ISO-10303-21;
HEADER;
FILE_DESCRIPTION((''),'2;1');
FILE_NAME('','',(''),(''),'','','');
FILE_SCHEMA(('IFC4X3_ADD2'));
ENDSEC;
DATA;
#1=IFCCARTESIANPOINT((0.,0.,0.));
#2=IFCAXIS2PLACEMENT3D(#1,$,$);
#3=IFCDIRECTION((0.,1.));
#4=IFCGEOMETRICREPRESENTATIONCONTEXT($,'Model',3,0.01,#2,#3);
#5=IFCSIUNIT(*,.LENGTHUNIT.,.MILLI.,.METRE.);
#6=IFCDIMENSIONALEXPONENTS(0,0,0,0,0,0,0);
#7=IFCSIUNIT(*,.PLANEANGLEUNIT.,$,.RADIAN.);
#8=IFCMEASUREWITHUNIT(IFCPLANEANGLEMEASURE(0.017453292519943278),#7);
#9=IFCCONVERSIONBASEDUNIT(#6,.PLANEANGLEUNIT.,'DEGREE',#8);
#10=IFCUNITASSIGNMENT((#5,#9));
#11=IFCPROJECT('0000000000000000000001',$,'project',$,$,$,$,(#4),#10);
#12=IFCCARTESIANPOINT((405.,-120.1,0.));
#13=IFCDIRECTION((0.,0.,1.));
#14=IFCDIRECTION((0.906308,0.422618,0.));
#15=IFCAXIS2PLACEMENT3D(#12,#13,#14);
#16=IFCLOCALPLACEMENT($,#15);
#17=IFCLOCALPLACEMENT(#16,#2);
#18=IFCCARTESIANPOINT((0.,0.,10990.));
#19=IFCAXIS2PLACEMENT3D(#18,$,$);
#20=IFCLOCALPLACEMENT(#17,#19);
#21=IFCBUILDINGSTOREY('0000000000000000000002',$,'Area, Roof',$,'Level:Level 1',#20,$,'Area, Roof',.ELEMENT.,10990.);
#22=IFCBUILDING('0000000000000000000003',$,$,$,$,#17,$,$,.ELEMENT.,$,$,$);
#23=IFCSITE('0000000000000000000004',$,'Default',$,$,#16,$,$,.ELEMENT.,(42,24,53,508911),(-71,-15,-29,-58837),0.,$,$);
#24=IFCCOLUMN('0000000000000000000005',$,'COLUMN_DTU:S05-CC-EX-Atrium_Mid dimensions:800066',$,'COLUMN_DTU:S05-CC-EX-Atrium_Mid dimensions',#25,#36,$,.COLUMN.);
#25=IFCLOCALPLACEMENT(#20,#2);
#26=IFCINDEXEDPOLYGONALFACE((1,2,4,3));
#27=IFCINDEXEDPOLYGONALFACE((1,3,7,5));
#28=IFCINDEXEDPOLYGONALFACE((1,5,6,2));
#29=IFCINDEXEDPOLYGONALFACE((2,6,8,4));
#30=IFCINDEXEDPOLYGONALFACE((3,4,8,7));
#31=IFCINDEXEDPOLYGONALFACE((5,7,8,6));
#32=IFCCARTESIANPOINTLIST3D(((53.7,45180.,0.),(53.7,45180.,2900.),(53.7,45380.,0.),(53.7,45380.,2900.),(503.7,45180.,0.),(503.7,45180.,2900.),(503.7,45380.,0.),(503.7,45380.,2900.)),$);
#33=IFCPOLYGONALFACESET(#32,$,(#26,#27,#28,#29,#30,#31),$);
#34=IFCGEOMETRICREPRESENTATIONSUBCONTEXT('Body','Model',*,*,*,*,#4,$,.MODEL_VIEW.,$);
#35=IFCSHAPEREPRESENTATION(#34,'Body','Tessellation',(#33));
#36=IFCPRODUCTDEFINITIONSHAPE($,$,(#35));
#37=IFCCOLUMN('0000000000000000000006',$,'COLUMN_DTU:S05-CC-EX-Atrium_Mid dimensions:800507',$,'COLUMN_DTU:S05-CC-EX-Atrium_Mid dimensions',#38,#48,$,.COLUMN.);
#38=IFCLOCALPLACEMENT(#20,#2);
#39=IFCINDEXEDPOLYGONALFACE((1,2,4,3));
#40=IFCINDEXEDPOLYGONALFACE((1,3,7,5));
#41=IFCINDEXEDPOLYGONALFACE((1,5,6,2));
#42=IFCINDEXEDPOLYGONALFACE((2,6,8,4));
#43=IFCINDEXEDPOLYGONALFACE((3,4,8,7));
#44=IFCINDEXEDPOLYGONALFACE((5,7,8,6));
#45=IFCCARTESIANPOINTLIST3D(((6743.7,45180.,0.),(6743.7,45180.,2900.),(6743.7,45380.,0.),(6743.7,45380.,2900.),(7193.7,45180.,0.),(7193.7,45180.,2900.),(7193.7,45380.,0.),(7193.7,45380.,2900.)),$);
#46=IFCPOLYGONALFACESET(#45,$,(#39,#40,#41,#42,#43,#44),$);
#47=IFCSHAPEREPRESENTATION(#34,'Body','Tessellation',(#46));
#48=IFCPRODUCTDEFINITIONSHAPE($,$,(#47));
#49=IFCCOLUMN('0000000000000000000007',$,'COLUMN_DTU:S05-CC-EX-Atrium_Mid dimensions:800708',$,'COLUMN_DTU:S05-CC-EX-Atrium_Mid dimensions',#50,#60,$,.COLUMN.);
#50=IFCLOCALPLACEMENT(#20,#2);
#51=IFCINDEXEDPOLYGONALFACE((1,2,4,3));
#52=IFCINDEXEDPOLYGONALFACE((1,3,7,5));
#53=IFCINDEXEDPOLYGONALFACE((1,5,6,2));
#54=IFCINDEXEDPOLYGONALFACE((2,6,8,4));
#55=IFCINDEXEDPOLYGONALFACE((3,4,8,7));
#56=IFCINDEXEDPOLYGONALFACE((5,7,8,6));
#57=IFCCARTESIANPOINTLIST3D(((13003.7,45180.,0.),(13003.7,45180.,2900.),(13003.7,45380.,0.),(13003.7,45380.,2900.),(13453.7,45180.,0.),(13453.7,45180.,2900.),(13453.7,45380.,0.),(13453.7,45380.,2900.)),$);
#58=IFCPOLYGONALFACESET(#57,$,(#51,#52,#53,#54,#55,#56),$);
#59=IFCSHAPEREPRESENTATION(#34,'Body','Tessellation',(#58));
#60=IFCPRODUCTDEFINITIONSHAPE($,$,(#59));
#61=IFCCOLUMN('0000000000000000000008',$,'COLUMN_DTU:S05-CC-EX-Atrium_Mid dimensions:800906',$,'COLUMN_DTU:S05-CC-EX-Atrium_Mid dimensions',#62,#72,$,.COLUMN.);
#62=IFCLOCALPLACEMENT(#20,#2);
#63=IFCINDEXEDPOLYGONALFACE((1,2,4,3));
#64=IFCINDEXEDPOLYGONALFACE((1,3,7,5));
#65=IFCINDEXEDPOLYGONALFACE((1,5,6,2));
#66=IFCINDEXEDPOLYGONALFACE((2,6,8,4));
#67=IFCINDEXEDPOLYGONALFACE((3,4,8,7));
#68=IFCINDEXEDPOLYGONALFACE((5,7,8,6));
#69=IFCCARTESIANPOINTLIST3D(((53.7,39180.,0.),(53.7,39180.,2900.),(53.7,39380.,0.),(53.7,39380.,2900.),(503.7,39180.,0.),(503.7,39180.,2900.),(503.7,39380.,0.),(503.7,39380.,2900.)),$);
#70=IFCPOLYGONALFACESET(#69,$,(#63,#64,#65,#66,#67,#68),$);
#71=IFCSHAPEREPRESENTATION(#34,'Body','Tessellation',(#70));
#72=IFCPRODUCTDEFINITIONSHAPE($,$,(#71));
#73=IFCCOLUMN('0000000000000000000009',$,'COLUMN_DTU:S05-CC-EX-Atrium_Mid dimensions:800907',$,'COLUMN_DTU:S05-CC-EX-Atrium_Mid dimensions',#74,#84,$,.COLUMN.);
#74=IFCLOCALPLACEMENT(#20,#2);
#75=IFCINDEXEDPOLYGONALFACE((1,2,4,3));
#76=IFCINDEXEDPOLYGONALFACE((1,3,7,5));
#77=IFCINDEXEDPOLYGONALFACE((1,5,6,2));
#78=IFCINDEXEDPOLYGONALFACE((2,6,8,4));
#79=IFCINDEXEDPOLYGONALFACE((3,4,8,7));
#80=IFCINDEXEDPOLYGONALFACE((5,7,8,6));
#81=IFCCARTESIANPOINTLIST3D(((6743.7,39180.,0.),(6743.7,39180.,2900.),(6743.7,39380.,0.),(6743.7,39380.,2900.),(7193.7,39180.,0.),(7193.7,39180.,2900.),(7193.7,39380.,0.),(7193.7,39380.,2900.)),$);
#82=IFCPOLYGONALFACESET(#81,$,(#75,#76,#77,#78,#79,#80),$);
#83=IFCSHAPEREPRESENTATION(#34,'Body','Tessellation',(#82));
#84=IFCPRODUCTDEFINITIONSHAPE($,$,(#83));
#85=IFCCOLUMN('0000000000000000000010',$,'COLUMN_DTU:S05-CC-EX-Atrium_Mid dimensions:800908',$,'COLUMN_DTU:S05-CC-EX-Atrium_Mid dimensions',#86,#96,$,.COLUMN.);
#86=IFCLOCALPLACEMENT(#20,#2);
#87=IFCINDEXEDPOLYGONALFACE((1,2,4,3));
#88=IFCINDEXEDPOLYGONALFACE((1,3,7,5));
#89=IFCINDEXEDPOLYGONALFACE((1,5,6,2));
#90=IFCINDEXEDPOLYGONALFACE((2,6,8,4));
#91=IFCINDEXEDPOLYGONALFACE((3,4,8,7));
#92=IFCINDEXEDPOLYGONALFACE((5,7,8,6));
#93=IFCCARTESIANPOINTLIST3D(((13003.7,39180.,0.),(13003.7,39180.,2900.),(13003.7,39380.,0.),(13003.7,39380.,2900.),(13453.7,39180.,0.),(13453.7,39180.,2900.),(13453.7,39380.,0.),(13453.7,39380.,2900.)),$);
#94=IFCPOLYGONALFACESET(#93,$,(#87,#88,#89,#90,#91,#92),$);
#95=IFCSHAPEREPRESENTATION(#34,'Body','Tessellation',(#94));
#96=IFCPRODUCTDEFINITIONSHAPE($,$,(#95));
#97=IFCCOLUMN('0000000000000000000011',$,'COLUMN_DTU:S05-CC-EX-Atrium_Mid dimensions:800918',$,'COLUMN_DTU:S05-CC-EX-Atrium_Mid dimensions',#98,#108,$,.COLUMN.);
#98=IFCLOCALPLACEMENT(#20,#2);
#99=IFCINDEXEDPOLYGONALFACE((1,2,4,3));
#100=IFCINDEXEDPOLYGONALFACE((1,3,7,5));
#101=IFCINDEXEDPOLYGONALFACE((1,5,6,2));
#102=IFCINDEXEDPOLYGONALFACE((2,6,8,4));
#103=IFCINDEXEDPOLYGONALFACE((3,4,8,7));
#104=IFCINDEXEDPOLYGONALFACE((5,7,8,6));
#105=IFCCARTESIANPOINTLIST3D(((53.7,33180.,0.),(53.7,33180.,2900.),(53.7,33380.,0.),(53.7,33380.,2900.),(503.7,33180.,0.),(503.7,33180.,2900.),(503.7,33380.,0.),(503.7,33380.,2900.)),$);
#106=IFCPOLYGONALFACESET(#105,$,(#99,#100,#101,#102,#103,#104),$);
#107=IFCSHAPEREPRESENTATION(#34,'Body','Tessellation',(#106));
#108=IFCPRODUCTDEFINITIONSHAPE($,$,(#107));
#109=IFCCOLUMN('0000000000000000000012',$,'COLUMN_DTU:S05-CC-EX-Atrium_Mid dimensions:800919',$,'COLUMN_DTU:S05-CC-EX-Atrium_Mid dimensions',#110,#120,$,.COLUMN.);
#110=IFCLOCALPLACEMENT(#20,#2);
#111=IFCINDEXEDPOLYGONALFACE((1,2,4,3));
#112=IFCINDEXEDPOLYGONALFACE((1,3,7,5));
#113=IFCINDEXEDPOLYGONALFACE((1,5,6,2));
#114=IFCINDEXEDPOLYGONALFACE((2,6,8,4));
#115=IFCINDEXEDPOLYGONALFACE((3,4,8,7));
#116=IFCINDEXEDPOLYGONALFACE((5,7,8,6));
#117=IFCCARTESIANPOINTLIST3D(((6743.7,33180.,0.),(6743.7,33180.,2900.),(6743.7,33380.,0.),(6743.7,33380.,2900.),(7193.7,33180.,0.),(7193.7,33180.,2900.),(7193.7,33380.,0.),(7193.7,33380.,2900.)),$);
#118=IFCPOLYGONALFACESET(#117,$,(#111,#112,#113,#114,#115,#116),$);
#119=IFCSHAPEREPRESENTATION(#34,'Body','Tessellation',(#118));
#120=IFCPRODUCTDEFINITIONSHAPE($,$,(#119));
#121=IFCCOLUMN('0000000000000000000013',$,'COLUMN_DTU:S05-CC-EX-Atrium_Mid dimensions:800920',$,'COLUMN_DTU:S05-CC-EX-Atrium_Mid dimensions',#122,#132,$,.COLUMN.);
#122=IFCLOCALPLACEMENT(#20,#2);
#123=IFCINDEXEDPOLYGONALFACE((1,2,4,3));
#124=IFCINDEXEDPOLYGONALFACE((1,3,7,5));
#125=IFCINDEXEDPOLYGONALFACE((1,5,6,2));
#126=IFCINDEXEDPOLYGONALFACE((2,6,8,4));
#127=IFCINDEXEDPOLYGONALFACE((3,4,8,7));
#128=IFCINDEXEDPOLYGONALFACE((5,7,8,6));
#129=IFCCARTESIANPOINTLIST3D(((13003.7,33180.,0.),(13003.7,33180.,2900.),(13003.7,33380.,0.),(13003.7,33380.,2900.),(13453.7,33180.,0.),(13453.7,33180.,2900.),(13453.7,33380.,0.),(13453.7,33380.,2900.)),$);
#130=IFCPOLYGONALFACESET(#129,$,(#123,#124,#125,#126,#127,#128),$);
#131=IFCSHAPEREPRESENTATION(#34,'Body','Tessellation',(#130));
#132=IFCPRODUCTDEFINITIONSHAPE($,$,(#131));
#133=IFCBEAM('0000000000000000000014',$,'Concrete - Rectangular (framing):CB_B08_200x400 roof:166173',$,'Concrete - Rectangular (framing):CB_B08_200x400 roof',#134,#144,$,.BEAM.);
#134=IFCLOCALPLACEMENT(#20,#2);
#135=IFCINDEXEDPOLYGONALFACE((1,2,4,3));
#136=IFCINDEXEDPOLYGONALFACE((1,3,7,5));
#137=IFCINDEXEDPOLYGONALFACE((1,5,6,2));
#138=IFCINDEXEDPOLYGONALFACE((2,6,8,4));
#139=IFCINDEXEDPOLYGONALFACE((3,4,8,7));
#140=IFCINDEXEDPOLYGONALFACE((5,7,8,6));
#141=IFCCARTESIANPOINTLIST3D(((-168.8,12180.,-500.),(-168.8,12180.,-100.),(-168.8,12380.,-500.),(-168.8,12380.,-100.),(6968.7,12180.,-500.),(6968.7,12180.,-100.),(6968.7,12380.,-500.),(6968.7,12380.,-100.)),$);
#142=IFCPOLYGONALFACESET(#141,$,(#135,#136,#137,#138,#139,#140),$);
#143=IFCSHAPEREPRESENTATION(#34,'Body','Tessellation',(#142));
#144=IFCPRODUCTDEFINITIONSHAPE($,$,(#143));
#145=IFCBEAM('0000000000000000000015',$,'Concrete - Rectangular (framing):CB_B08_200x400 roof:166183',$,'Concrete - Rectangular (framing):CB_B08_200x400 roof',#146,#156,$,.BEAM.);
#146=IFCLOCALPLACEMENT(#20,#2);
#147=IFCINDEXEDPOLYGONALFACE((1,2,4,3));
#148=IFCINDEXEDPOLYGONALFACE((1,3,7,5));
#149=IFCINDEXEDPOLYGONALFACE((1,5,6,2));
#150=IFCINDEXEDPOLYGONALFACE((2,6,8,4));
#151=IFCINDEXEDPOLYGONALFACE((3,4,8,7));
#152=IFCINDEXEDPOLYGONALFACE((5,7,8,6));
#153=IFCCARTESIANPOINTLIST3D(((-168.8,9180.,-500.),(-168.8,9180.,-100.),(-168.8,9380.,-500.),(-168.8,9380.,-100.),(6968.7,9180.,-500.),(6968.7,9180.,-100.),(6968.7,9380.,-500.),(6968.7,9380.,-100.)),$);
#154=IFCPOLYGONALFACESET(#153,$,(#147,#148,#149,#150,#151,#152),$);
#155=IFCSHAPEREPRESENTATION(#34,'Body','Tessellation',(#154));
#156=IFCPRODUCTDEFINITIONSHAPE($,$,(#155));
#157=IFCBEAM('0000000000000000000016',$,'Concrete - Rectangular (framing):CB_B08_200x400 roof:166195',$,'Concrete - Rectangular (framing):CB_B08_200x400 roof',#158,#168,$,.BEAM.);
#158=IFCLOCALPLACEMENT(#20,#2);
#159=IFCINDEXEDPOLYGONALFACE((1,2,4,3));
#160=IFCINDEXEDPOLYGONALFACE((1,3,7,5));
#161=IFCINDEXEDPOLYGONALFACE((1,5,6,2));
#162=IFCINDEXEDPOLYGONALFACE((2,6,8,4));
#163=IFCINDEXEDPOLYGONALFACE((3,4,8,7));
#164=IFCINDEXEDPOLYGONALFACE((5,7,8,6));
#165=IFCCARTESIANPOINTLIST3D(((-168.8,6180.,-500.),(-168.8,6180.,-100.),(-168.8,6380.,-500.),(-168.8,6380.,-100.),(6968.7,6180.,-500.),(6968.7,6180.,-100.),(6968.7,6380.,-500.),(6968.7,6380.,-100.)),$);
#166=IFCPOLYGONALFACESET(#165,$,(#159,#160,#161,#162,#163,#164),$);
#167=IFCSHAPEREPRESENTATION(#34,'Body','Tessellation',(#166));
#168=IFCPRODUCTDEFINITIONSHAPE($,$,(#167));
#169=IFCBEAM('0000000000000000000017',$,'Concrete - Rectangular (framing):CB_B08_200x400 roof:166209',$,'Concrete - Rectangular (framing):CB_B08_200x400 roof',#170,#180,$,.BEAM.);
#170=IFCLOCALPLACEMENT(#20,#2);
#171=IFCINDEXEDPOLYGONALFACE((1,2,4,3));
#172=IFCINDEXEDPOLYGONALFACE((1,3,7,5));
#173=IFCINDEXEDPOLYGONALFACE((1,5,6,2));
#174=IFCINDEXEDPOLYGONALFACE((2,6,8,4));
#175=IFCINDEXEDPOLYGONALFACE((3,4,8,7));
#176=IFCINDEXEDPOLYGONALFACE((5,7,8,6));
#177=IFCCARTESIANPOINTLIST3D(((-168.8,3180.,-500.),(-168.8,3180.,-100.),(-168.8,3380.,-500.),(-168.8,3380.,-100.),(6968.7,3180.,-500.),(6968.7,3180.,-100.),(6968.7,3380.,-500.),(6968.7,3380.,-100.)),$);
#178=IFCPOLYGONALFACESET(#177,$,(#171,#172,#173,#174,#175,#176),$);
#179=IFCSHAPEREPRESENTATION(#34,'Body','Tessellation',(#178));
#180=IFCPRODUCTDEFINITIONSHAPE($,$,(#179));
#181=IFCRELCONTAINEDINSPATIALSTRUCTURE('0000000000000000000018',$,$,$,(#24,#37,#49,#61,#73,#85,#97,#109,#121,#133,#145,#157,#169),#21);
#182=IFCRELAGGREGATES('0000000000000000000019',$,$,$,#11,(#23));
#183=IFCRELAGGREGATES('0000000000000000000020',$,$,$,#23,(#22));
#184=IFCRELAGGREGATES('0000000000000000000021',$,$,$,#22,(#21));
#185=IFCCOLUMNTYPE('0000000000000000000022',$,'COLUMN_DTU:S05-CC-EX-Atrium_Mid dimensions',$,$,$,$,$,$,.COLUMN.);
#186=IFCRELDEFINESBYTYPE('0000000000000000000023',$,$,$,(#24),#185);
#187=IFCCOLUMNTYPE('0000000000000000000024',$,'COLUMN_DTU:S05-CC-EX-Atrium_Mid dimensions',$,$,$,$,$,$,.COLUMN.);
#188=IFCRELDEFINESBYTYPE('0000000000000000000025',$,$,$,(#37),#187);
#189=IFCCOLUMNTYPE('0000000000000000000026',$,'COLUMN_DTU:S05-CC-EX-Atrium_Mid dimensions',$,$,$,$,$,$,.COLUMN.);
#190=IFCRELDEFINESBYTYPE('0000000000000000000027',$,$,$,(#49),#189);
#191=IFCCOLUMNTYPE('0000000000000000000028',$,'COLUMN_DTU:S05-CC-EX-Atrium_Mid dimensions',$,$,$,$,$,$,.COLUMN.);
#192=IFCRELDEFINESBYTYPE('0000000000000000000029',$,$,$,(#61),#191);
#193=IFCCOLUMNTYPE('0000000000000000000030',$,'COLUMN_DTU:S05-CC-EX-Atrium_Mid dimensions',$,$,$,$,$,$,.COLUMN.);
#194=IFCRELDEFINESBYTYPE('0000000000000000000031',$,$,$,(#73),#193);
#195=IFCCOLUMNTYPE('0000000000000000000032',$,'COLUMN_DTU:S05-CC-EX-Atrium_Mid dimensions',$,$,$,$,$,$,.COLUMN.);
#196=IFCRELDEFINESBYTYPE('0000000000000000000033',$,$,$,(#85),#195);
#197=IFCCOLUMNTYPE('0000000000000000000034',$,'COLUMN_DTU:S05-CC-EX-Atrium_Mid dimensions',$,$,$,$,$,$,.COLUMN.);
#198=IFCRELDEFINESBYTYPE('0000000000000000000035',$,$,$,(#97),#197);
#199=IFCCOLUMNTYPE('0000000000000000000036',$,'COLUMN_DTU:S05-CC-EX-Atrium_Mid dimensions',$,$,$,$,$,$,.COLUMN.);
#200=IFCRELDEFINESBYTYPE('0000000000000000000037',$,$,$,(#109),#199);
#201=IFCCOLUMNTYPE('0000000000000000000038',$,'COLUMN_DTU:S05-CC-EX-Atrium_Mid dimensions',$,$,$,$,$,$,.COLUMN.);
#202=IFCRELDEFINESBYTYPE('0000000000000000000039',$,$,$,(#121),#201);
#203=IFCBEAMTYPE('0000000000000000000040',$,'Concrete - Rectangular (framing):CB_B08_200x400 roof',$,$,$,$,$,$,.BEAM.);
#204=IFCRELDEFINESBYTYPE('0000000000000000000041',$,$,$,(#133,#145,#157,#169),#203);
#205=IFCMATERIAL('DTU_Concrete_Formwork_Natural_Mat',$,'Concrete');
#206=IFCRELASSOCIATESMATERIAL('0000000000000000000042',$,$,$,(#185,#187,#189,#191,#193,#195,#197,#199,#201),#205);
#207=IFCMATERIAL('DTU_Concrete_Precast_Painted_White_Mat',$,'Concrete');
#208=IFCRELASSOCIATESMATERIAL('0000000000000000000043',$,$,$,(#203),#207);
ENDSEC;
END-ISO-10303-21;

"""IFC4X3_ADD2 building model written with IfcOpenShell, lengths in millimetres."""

from ifc_helpers import new_model, entity, si_unit, converted_unit, direction, frame, frame_2d, origin, origin_2d_with_axis, place, context, subcontext, project, spatial, rectangle, extrude, source, transform, mapped, material, material_profile, profile_set, type_object, type_shapes, element, save


model = new_model("IFC4X3_ADD2")

# Units and contexts
model_context = context("Model", 3, precision=0.01, world=origin(), true_north=direction((0.0, 1.0)))
body_context = subcontext(model_context, "Body", "Model", "MODEL_VIEW")
ifc_project = project(units=[si_unit("LENGTHUNIT", "METRE", prefix="MILLI"), converted_unit("PLANEANGLEUNIT", "DEGREE", entity("IfcPlaneAngleMeasure", 0.017453292519943278), si_unit("PLANEANGLEUNIT", "RADIAN"), dimensions=[0, 0, 0, 0, 0, 0, 0])], contexts=[model_context])

# Site, building, storey
site_placement = place(None, frame((405.0, -120.1, 0.0), z_axis=(0.0, 0.0, 1.0), x_axis=(0.906308, 0.422618, 0.0)))
site = spatial("IfcSite", under=ifc_project, at=site_placement, Name="Default", CompositionType="ELEMENT", RefLatitude=(42, 24, 53, 508911), RefLongitude=(-71, -15, -29, -58837), RefElevation=0.0)
building_placement = place(site_placement, origin())
building = spatial("IfcBuilding", under=site, at=building_placement, CompositionType="ELEMENT")
storey_placement = place(building_placement, frame((0.0, 0.0, 10990.0)))
storey = spatial("IfcBuildingStorey", under=building, at=storey_placement, Name="Area, Roof", ObjectType="Level:Level 1", LongName="Area, Roof", CompositionType="ELEMENT", Elevation=10990.0)

# Columns
ifc_material_1 = material(Name="DTU_Concrete_Formwork_Natural_Mat", Category="Concrete")
ifc_material_profile_1 = material_profile(ifc_material_1, rectangle(XDim=200.0, YDim=450.0, at=frame_2d((0.0, 0.0), x_axis=(1.0, 0.0))), Name="S05-CC-EX-Atrium_Mid dimensions")
ifc_profile_set_1 = profile_set([ifc_material_profile_1], Name="S05-CC-EX-Atrium_Mid dimensions")
column_type_1 = type_object("IfcColumnType", Name="COLUMN_DTU:S05-CC-EX-Atrium_Mid dimensions", PredefinedType="COLUMN", material=ifc_profile_set_1)
shared_shape_1 = source(origin(), body_context, "Body", "SweptSolid", [
    extrude(rectangle(XDim=200.0, YDim=450.0, at=frame_2d((0.0, 0.0), x_axis=(1.0, 0.0))), frame((278.7, 45280.0, 10990.0), z_axis=(0.0, 0.0, 1.0), x_axis=(0.0, -1.0, 0.0)), (0.0, 0.0, 1.0), 2900.0),
])
type_shapes(column_type_1, [shared_shape_1])
column_1_placement = place(storey_placement, frame((0.0, 0.0, -10990.0)))
element("IfcColumn", 1, at=column_1_placement, inside=storey, type_object=column_type_1, Name="COLUMN_DTU:S05-CC-EX-Atrium_Mid dimensions:800066", ObjectType="COLUMN_DTU:S05-CC-EX-Atrium_Mid dimensions", PredefinedType="COLUMN", context=body_context, shape_type="MappedRepresentation", body=[
    mapped(shared_shape_1, transform((0.0, 0.0, 0.0), scale=1.0)),
])
column_type_2 = type_object("IfcColumnType", Name="COLUMN_DTU:S05-CC-EX-Atrium_Mid dimensions", PredefinedType="COLUMN", material=ifc_profile_set_1)
shared_shape_2 = source(origin(), body_context, "Body", "SweptSolid", [
    extrude(rectangle(XDim=200.0, YDim=450.0, at=frame_2d((0.0, 0.0), x_axis=(1.0, 0.0))), frame((6968.7, 45280.0, 10990.0), z_axis=(0.0, 0.0, 1.0), x_axis=(0.0, -1.0, 0.0)), (0.0, 0.0, 1.0), 2900.0),
])
type_shapes(column_type_2, [shared_shape_2])
column_2_placement = place(storey_placement, frame((0.0, 0.0, -10990.0)))
element("IfcColumn", 2, at=column_2_placement, inside=storey, type_object=column_type_2, Name="COLUMN_DTU:S05-CC-EX-Atrium_Mid dimensions:800507", ObjectType="COLUMN_DTU:S05-CC-EX-Atrium_Mid dimensions", PredefinedType="COLUMN", context=body_context, shape_type="MappedRepresentation", body=[
    mapped(shared_shape_2, transform((0.0, 0.0, 0.0), scale=1.0)),
])
column_type_3 = type_object("IfcColumnType", Name="COLUMN_DTU:S05-CC-EX-Atrium_Mid dimensions", PredefinedType="COLUMN", material=ifc_profile_set_1)
shared_shape_3 = source(origin(), body_context, "Body", "SweptSolid", [
    extrude(rectangle(XDim=200.0, YDim=450.0, at=frame_2d((0.0, 0.0), x_axis=(1.0, 0.0))), frame((13228.7, 45280.0, 10990.0), z_axis=(0.0, 0.0, 1.0), x_axis=(0.0, -1.0, 0.0)), (0.0, 0.0, 1.0), 2900.0),
])
type_shapes(column_type_3, [shared_shape_3])
column_3_placement = place(storey_placement, frame((0.0, 0.0, -10990.0)))
element("IfcColumn", 3, at=column_3_placement, inside=storey, type_object=column_type_3, Name="COLUMN_DTU:S05-CC-EX-Atrium_Mid dimensions:800708", ObjectType="COLUMN_DTU:S05-CC-EX-Atrium_Mid dimensions", PredefinedType="COLUMN", context=body_context, shape_type="MappedRepresentation", body=[
    mapped(shared_shape_3, transform((0.0, 0.0, 0.0), scale=1.0)),
])
column_type_4 = type_object("IfcColumnType", Name="COLUMN_DTU:S05-CC-EX-Atrium_Mid dimensions", PredefinedType="COLUMN", material=ifc_profile_set_1)
shared_shape_4 = source(origin(), body_context, "Body", "SweptSolid", [
    extrude(rectangle(XDim=200.0, YDim=450.0, at=frame_2d((0.0, 0.0), x_axis=(1.0, 0.0))), frame((278.7, 39280.0, 10990.0), z_axis=(0.0, 0.0, 1.0), x_axis=(0.0, -1.0, 0.0)), (0.0, 0.0, 1.0), 2900.0),
])
type_shapes(column_type_4, [shared_shape_4])
column_4_placement = place(storey_placement, frame((0.0, 0.0, -10990.0)))
element("IfcColumn", 4, at=column_4_placement, inside=storey, type_object=column_type_4, Name="COLUMN_DTU:S05-CC-EX-Atrium_Mid dimensions:800906", ObjectType="COLUMN_DTU:S05-CC-EX-Atrium_Mid dimensions", PredefinedType="COLUMN", context=body_context, shape_type="MappedRepresentation", body=[
    mapped(shared_shape_4, transform((0.0, 0.0, 0.0), scale=1.0)),
])
column_type_5 = type_object("IfcColumnType", Name="COLUMN_DTU:S05-CC-EX-Atrium_Mid dimensions", PredefinedType="COLUMN", material=ifc_profile_set_1)
shared_shape_5 = source(origin(), body_context, "Body", "SweptSolid", [
    extrude(rectangle(XDim=200.0, YDim=450.0, at=frame_2d((0.0, 0.0), x_axis=(1.0, 0.0))), frame((6968.7, 39280.0, 10990.0), z_axis=(0.0, 0.0, 1.0), x_axis=(0.0, -1.0, 0.0)), (0.0, 0.0, 1.0), 2900.0),
])
type_shapes(column_type_5, [shared_shape_5])
column_5_placement = place(storey_placement, frame((0.0, 0.0, -10990.0)))
element("IfcColumn", 5, at=column_5_placement, inside=storey, type_object=column_type_5, Name="COLUMN_DTU:S05-CC-EX-Atrium_Mid dimensions:800907", ObjectType="COLUMN_DTU:S05-CC-EX-Atrium_Mid dimensions", PredefinedType="COLUMN", context=body_context, shape_type="MappedRepresentation", body=[
    mapped(shared_shape_5, transform((0.0, 0.0, 0.0), scale=1.0)),
])
column_type_6 = type_object("IfcColumnType", Name="COLUMN_DTU:S05-CC-EX-Atrium_Mid dimensions", PredefinedType="COLUMN", material=ifc_profile_set_1)
shared_shape_6 = source(origin(), body_context, "Body", "SweptSolid", [
    extrude(rectangle(XDim=200.0, YDim=450.0, at=frame_2d((0.0, 0.0), x_axis=(1.0, 0.0))), frame((13228.7, 39280.0, 10990.0), z_axis=(0.0, 0.0, 1.0), x_axis=(0.0, -1.0, 0.0)), (0.0, 0.0, 1.0), 2900.0),
])
type_shapes(column_type_6, [shared_shape_6])
column_6_placement = place(storey_placement, frame((0.0, 0.0, -10990.0)))
element("IfcColumn", 6, at=column_6_placement, inside=storey, type_object=column_type_6, Name="COLUMN_DTU:S05-CC-EX-Atrium_Mid dimensions:800908", ObjectType="COLUMN_DTU:S05-CC-EX-Atrium_Mid dimensions", PredefinedType="COLUMN", context=body_context, shape_type="MappedRepresentation", body=[
    mapped(shared_shape_6, transform((0.0, 0.0, 0.0), scale=1.0)),
])
column_type_7 = type_object("IfcColumnType", Name="COLUMN_DTU:S05-CC-EX-Atrium_Mid dimensions", PredefinedType="COLUMN", material=ifc_profile_set_1)
shared_shape_7 = source(origin(), body_context, "Body", "SweptSolid", [
    extrude(rectangle(XDim=200.0, YDim=450.0, at=frame_2d((0.0, 0.0), x_axis=(1.0, 0.0))), frame((278.7, 33280.0, 10990.0), z_axis=(0.0, 0.0, 1.0), x_axis=(0.0, -1.0, 0.0)), (0.0, 0.0, 1.0), 2900.0),
])
type_shapes(column_type_7, [shared_shape_7])
column_7_placement = place(storey_placement, frame((0.0, 0.0, -10990.0)))
element("IfcColumn", 7, at=column_7_placement, inside=storey, type_object=column_type_7, Name="COLUMN_DTU:S05-CC-EX-Atrium_Mid dimensions:800918", ObjectType="COLUMN_DTU:S05-CC-EX-Atrium_Mid dimensions", PredefinedType="COLUMN", context=body_context, shape_type="MappedRepresentation", body=[
    mapped(shared_shape_7, transform((0.0, 0.0, 0.0), scale=1.0)),
])
column_type_8 = type_object("IfcColumnType", Name="COLUMN_DTU:S05-CC-EX-Atrium_Mid dimensions", PredefinedType="COLUMN", material=ifc_profile_set_1)
shared_shape_8 = source(origin(), body_context, "Body", "SweptSolid", [
    extrude(rectangle(XDim=200.0, YDim=450.0, at=frame_2d((0.0, 0.0), x_axis=(1.0, 0.0))), frame((6968.7, 33280.0, 10990.0), z_axis=(0.0, 0.0, 1.0), x_axis=(0.0, -1.0, 0.0)), (0.0, 0.0, 1.0), 2900.0),
])
type_shapes(column_type_8, [shared_shape_8])
column_8_placement = place(storey_placement, frame((0.0, 0.0, -10990.0)))
element("IfcColumn", 8, at=column_8_placement, inside=storey, type_object=column_type_8, Name="COLUMN_DTU:S05-CC-EX-Atrium_Mid dimensions:800919", ObjectType="COLUMN_DTU:S05-CC-EX-Atrium_Mid dimensions", PredefinedType="COLUMN", context=body_context, shape_type="MappedRepresentation", body=[
    mapped(shared_shape_8, transform((0.0, 0.0, 0.0), scale=1.0)),
])
column_type_9 = type_object("IfcColumnType", Name="COLUMN_DTU:S05-CC-EX-Atrium_Mid dimensions", PredefinedType="COLUMN", material=ifc_profile_set_1)
shared_shape_9 = source(origin(), body_context, "Body", "SweptSolid", [
    extrude(rectangle(XDim=200.0, YDim=450.0, at=frame_2d((0.0, 0.0), x_axis=(1.0, 0.0))), frame((13228.7, 33280.0, 10990.0), z_axis=(0.0, 0.0, 1.0), x_axis=(0.0, -1.0, 0.0)), (0.0, 0.0, 1.0), 2900.0),
])
type_shapes(column_type_9, [shared_shape_9])
column_9_placement = place(storey_placement, frame((0.0, 0.0, -10990.0)))
element("IfcColumn", 9, at=column_9_placement, inside=storey, type_object=column_type_9, Name="COLUMN_DTU:S05-CC-EX-Atrium_Mid dimensions:800920", ObjectType="COLUMN_DTU:S05-CC-EX-Atrium_Mid dimensions", PredefinedType="COLUMN", context=body_context, shape_type="MappedRepresentation", body=[
    mapped(shared_shape_9, transform((0.0, 0.0, 0.0), scale=1.0)),
])

# Beams
ifc_material_2 = material(Name="DTU_Concrete_Precast_Painted_White_Mat", Category="Concrete")
ifc_material_profile_2 = material_profile(ifc_material_2, rectangle(XDim=7137.5, YDim=200.0, at=origin_2d_with_axis()), Name="CB_B08_200x400 roof")
ifc_profile_set_2 = profile_set([ifc_material_profile_2], Name="CB_B08_200x400 roof")
beam_type_1 = type_object("IfcBeamType", Name="Concrete - Rectangular (framing):CB_B08_200x400 roof", PredefinedType="BEAM", material=ifc_profile_set_2)
shared_shape_10 = source(origin(), body_context, "Body", "SweptSolid", [
    extrude(rectangle(XDim=7137.5, YDim=200.0, at=origin_2d_with_axis()), frame((6.3, 0.0, -200.0), z_axis=(0.0, 0.0, 1.0), x_axis=(-1.0, 0.0, 0.0)), (0.0, 0.0, 1.0), 400.0),
])
type_shapes(beam_type_1, [shared_shape_10])
for number, where, z_axis, x_axis, name in (
    (10, (3406.2, 12280.0, -300.0), (0.0, 0.0, 1.0), (-1.0, 0.0, 0.0), "Concrete - Rectangular (framing):CB_B08_200x400 roof:166173"),
    (11, (3406.2, 9280.0, -300.0), (0.0, 0.0, 1.0), (-1.0, 0.0, 0.0), "Concrete - Rectangular (framing):CB_B08_200x400 roof:166183"),
    (12, (3406.2, 6280.0, -300.0), (0.0, 0.0, 1.0), (-1.0, 0.0, 0.0), "Concrete - Rectangular (framing):CB_B08_200x400 roof:166195"),
    (13, (3406.2, 3280.0, -300.0), (0.0, 0.0, 1.0), (-1.0, 0.0, 0.0), "Concrete - Rectangular (framing):CB_B08_200x400 roof:166209"),
):
    element("IfcBeam", number, at=place(storey_placement, frame(where, z_axis=z_axis, x_axis=x_axis)), inside=storey, type_object=beam_type_1, Name=name, ObjectType="Concrete - Rectangular (framing):CB_B08_200x400 roof", PredefinedType="BEAM", context=body_context, shape_type="MappedRepresentation", body=[
        mapped(shared_shape_10, transform((0.0, 0.0, 0.0), scale=1.0)),
    ])

save(model, "model.ifc")
